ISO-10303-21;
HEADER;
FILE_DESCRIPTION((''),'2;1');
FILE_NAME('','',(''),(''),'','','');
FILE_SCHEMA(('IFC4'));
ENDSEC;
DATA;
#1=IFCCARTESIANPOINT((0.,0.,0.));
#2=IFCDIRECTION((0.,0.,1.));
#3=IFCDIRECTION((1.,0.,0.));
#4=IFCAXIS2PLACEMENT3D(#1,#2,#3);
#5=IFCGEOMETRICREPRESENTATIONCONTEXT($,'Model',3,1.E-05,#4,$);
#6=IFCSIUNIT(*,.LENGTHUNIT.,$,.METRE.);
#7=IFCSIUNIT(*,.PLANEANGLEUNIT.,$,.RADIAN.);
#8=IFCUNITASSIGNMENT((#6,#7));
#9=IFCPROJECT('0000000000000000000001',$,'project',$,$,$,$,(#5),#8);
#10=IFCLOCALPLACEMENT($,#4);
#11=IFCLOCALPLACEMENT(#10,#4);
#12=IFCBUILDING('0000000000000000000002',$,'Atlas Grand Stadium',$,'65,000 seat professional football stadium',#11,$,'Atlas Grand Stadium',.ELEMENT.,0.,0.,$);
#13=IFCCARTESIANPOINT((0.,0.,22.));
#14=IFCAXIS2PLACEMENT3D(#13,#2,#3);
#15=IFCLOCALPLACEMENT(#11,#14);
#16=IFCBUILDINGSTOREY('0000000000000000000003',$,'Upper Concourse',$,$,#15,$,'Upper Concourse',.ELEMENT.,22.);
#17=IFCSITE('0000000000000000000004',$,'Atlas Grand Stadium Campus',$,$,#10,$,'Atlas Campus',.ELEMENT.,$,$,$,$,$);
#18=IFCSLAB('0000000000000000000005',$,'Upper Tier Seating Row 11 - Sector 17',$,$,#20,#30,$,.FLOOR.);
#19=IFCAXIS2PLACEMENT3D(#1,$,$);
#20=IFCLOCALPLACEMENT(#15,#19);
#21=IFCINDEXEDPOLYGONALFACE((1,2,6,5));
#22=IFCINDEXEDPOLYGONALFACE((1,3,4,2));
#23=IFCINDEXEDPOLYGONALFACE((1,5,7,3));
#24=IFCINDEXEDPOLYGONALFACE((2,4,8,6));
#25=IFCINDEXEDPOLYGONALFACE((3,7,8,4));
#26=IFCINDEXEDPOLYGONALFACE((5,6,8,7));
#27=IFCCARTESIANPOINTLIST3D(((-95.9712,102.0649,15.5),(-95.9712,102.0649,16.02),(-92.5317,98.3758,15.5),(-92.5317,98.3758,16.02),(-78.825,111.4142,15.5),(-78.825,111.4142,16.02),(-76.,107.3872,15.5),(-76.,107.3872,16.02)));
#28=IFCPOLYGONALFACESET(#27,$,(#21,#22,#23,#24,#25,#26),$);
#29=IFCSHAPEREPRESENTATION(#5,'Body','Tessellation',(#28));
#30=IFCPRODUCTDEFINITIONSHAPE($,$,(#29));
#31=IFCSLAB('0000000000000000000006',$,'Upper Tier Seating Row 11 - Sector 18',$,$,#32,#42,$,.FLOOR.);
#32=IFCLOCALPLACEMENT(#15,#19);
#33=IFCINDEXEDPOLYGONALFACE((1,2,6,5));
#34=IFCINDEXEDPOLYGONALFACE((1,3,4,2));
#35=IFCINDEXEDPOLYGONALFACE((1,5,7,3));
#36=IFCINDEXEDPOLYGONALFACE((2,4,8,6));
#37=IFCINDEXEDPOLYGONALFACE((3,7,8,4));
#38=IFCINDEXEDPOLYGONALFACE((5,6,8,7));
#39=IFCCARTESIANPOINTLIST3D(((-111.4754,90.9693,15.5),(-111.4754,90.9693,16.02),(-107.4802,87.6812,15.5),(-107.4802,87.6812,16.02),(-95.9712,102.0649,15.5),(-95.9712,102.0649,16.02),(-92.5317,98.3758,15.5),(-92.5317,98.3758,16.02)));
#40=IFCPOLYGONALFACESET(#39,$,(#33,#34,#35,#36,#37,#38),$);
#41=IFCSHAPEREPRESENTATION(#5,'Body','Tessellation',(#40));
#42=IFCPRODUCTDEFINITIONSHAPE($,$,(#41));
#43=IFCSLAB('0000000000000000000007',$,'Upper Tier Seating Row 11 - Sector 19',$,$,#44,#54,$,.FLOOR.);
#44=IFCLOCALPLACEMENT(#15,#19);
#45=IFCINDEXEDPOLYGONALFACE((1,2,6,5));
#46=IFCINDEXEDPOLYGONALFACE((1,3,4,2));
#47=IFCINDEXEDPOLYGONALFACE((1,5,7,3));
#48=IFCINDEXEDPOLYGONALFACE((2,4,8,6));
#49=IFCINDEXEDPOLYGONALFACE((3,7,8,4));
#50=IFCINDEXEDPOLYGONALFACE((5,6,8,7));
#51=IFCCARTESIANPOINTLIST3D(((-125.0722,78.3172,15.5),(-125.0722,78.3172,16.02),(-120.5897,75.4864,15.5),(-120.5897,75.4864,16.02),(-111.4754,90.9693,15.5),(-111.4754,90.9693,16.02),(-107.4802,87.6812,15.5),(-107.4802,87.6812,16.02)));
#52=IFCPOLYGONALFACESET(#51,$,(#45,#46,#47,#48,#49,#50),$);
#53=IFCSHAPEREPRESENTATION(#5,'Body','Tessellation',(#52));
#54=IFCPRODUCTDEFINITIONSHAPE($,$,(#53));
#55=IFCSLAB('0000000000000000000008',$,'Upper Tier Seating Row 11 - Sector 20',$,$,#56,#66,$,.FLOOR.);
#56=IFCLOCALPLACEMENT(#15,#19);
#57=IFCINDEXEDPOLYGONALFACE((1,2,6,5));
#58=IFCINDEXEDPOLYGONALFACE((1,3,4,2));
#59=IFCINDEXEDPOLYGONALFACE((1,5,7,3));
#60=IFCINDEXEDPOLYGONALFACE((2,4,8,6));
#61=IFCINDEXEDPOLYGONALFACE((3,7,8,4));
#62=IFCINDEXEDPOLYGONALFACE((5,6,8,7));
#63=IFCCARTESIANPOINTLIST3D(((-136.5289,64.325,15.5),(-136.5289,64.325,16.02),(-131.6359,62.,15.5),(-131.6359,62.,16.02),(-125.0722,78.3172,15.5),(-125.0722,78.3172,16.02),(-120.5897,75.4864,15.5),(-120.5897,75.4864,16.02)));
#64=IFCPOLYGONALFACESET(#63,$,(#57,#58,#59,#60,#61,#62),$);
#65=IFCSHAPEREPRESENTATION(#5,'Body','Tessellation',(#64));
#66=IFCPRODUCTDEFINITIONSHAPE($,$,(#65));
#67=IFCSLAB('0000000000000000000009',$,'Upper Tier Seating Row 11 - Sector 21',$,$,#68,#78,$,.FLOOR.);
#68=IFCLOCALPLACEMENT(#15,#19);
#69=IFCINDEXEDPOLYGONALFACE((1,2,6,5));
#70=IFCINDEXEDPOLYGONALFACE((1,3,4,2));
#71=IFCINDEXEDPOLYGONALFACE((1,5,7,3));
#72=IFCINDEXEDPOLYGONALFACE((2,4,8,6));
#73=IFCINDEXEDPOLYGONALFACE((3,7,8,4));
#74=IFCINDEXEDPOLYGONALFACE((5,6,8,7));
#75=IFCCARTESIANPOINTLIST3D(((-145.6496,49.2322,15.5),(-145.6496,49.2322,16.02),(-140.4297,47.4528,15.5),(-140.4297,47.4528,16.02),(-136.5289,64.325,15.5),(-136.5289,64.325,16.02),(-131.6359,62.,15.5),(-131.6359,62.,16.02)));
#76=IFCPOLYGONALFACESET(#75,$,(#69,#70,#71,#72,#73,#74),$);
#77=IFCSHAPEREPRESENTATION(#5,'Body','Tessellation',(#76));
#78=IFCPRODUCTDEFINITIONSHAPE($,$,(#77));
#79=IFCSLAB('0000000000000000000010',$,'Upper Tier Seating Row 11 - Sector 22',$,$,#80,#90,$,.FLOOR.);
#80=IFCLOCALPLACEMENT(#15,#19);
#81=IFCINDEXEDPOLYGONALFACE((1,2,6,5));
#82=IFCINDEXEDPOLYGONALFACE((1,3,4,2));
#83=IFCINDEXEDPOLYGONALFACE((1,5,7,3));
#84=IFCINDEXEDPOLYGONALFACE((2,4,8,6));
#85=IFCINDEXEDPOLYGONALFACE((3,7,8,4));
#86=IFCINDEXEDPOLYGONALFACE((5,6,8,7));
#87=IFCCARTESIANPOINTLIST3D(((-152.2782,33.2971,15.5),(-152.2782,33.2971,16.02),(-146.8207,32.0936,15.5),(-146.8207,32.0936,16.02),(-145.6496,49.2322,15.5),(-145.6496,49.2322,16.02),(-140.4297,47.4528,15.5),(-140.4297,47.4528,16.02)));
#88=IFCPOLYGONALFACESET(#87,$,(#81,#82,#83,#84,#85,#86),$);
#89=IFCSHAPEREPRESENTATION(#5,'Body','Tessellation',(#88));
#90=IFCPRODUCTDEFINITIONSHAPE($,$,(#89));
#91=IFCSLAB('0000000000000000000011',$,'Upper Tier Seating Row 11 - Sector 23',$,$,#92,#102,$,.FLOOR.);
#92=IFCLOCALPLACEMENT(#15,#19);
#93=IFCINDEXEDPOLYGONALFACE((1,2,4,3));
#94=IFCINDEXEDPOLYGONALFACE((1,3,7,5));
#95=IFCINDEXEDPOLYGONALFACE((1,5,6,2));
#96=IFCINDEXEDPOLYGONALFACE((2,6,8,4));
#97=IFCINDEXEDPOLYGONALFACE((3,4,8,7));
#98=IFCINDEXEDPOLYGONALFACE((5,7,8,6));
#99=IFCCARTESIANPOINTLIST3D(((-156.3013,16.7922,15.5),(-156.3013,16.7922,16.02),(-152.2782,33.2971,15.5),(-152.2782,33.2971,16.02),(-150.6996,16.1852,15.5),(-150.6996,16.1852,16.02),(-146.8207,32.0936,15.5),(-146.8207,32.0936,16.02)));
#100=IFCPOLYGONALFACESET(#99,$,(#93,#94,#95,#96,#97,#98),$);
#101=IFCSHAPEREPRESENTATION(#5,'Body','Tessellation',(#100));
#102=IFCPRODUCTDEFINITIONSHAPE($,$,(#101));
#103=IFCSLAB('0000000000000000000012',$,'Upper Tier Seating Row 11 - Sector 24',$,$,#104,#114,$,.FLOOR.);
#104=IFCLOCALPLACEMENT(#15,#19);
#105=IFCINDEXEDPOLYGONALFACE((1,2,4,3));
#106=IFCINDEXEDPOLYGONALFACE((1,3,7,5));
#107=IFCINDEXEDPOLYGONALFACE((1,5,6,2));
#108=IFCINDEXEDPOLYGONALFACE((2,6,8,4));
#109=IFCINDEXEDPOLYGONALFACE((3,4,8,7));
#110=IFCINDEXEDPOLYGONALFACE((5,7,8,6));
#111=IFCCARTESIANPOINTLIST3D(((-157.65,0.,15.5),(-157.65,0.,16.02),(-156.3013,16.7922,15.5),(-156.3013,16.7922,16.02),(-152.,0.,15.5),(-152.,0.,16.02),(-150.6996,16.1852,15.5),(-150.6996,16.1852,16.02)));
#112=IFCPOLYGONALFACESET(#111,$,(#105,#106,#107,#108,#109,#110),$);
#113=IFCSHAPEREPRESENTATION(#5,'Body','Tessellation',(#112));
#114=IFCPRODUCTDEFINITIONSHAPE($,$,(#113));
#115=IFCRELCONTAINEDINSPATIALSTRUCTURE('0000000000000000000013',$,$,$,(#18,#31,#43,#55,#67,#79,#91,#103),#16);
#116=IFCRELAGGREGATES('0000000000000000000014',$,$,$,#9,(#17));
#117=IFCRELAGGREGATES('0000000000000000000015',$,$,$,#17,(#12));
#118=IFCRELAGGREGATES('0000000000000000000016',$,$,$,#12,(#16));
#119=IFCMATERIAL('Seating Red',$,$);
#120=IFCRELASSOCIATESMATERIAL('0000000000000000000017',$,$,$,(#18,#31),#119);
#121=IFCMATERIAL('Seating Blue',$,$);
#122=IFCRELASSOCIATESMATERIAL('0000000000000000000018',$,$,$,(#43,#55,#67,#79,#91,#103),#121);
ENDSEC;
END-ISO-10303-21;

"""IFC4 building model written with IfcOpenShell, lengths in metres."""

from ifc_helpers import new_model, si_unit, frame, origin_with_axes, place, context, project, spatial, polyline, outline, extrude, material, element, save


model = new_model("IFC4")

# Units and contexts
model_context = context("Model", 3, precision=1e-05, world=origin_with_axes())
ifc_project = project(units=[si_unit("LENGTHUNIT", "METRE"), si_unit("PLANEANGLEUNIT", "RADIAN")], contexts=[model_context])

# Site, building, storey
site_placement = place(None, origin_with_axes())
site = spatial("IfcSite", under=ifc_project, at=site_placement, Name="Atlas Grand Stadium Campus", LongName="Atlas Campus", CompositionType="ELEMENT")
building_placement = place(site_placement, origin_with_axes())
building = spatial("IfcBuilding", under=site, at=building_placement, Name="Atlas Grand Stadium", ObjectType="65,000 seat professional football stadium", LongName="Atlas Grand Stadium", CompositionType="ELEMENT", ElevationOfRefHeight=0.0, ElevationOfTerrain=0.0)
storey_placement = place(building_placement, frame((0.0, 0.0, 22.0), z_axis=(0.0, 0.0, 1.0), x_axis=(1.0, 0.0, 0.0)))
storey = spatial("IfcBuildingStorey", under=building, at=storey_placement, Name="Upper Concourse", LongName="Upper Concourse", CompositionType="ELEMENT", Elevation=22.0)

# Slabs
ifc_material_1 = material(Name="Seating Blue")
ifc_material_2 = material(Name="Seating Red")
slab_1_placement = place(storey_placement, frame((0.0, 0.0, 15.5), z_axis=(0.0, 0.0, 1.0), x_axis=(1.0, 0.0, 0.0)))
element("IfcSlab", 1, at=slab_1_placement, inside=storey, material=ifc_material_2, Name="Upper Tier Seating Row 11 - Sector 17", PredefinedType="FLOOR", context=model_context, shape_type="SweptSolid", body=[
    extrude(outline(polyline([(-78.825, 111.4142), (-95.9712, 102.0649), (-92.5317, 98.3758), (-76.0, 107.3872), (-78.825, 111.4142)])), origin_with_axes(), (0.0, 0.0, 1.0), 0.52),
])
slab_2_placement = place(storey_placement, frame((0.0, 0.0, 15.5), z_axis=(0.0, 0.0, 1.0), x_axis=(1.0, 0.0, 0.0)))
element("IfcSlab", 2, at=slab_2_placement, inside=storey, material=ifc_material_2, Name="Upper Tier Seating Row 11 - Sector 18", PredefinedType="FLOOR", context=model_context, shape_type="SweptSolid", body=[
    extrude(outline(polyline([(-95.9712, 102.0649), (-111.4754, 90.9693), (-107.4802, 87.6812), (-92.5317, 98.3758), (-95.9712, 102.0649)])), origin_with_axes(), (0.0, 0.0, 1.0), 0.52),
])
slab_3_placement = place(storey_placement, frame((0.0, 0.0, 15.5), z_axis=(0.0, 0.0, 1.0), x_axis=(1.0, 0.0, 0.0)))
element("IfcSlab", 3, at=slab_3_placement, inside=storey, material=ifc_material_1, Name="Upper Tier Seating Row 11 - Sector 19", PredefinedType="FLOOR", context=model_context, shape_type="SweptSolid", body=[
    extrude(outline(polyline([(-111.4754, 90.9693), (-125.0721, 78.3172), (-120.5897, 75.4864), (-107.4802, 87.6812), (-111.4754, 90.9693)])), origin_with_axes(), (0.0, 0.0, 1.0), 0.52),
])
slab_4_placement = place(storey_placement, frame((0.0, 0.0, 15.5), z_axis=(0.0, 0.0, 1.0), x_axis=(1.0, 0.0, 0.0)))
element("IfcSlab", 4, at=slab_4_placement, inside=storey, material=ifc_material_1, Name="Upper Tier Seating Row 11 - Sector 20", PredefinedType="FLOOR", context=model_context, shape_type="SweptSolid", body=[
    extrude(outline(polyline([(-125.0721, 78.3172), (-136.5289, 64.325), (-131.6359, 62.0), (-120.5897, 75.4864), (-125.0721, 78.3172)])), origin_with_axes(), (0.0, 0.0, 1.0), 0.52),
])
slab_5_placement = place(storey_placement, frame((0.0, 0.0, 15.5), z_axis=(0.0, 0.0, 1.0), x_axis=(1.0, 0.0, 0.0)))
element("IfcSlab", 5, at=slab_5_placement, inside=storey, material=ifc_material_1, Name="Upper Tier Seating Row 11 - Sector 21", PredefinedType="FLOOR", context=model_context, shape_type="SweptSolid", body=[
    extrude(outline(polyline([(-136.5289, 64.325), (-145.6496, 49.2322), (-140.4297, 47.4528), (-131.6359, 62.0), (-136.5289, 64.325)])), origin_with_axes(), (0.0, 0.0, 1.0), 0.52),
])
slab_6_placement = place(storey_placement, frame((0.0, 0.0, 15.5), z_axis=(0.0, 0.0, 1.0), x_axis=(1.0, 0.0, 0.0)))
element("IfcSlab", 6, at=slab_6_placement, inside=storey, material=ifc_material_1, Name="Upper Tier Seating Row 11 - Sector 22", PredefinedType="FLOOR", context=model_context, shape_type="SweptSolid", body=[
    extrude(outline(polyline([(-145.6496, 49.2322), (-152.2782, 33.2971), (-146.8207, 32.0936), (-140.4297, 47.4528), (-145.6496, 49.2322)])), origin_with_axes(), (0.0, 0.0, 1.0), 0.52),
])
slab_7_placement = place(storey_placement, frame((0.0, 0.0, 15.5), z_axis=(0.0, 0.0, 1.0), x_axis=(1.0, 0.0, 0.0)))
element("IfcSlab", 7, at=slab_7_placement, inside=storey, material=ifc_material_1, Name="Upper Tier Seating Row 11 - Sector 23", PredefinedType="FLOOR", context=model_context, shape_type="SweptSolid", body=[
    extrude(outline(polyline([(-152.2782, 33.2971), (-156.3013, 16.7922), (-150.6996, 16.1852), (-146.8207, 32.0936), (-152.2782, 33.2971)])), origin_with_axes(), (0.0, 0.0, 1.0), 0.52),
])
slab_8_placement = place(storey_placement, frame((0.0, 0.0, 15.5), z_axis=(0.0, 0.0, 1.0), x_axis=(1.0, 0.0, 0.0)))
element("IfcSlab", 8, at=slab_8_placement, inside=storey, material=ifc_material_1, Name="Upper Tier Seating Row 11 - Sector 24", PredefinedType="FLOOR", context=model_context, shape_type="SweptSolid", body=[
    extrude(outline(polyline([(-156.3013, 16.7922), (-157.65, 0.0), (-152.0, 0.0), (-150.6996, 16.1852), (-156.3013, 16.7922)])), origin_with_axes(), (0.0, 0.0, 1.0), 0.52),
])

save(model, "model.ifc")
